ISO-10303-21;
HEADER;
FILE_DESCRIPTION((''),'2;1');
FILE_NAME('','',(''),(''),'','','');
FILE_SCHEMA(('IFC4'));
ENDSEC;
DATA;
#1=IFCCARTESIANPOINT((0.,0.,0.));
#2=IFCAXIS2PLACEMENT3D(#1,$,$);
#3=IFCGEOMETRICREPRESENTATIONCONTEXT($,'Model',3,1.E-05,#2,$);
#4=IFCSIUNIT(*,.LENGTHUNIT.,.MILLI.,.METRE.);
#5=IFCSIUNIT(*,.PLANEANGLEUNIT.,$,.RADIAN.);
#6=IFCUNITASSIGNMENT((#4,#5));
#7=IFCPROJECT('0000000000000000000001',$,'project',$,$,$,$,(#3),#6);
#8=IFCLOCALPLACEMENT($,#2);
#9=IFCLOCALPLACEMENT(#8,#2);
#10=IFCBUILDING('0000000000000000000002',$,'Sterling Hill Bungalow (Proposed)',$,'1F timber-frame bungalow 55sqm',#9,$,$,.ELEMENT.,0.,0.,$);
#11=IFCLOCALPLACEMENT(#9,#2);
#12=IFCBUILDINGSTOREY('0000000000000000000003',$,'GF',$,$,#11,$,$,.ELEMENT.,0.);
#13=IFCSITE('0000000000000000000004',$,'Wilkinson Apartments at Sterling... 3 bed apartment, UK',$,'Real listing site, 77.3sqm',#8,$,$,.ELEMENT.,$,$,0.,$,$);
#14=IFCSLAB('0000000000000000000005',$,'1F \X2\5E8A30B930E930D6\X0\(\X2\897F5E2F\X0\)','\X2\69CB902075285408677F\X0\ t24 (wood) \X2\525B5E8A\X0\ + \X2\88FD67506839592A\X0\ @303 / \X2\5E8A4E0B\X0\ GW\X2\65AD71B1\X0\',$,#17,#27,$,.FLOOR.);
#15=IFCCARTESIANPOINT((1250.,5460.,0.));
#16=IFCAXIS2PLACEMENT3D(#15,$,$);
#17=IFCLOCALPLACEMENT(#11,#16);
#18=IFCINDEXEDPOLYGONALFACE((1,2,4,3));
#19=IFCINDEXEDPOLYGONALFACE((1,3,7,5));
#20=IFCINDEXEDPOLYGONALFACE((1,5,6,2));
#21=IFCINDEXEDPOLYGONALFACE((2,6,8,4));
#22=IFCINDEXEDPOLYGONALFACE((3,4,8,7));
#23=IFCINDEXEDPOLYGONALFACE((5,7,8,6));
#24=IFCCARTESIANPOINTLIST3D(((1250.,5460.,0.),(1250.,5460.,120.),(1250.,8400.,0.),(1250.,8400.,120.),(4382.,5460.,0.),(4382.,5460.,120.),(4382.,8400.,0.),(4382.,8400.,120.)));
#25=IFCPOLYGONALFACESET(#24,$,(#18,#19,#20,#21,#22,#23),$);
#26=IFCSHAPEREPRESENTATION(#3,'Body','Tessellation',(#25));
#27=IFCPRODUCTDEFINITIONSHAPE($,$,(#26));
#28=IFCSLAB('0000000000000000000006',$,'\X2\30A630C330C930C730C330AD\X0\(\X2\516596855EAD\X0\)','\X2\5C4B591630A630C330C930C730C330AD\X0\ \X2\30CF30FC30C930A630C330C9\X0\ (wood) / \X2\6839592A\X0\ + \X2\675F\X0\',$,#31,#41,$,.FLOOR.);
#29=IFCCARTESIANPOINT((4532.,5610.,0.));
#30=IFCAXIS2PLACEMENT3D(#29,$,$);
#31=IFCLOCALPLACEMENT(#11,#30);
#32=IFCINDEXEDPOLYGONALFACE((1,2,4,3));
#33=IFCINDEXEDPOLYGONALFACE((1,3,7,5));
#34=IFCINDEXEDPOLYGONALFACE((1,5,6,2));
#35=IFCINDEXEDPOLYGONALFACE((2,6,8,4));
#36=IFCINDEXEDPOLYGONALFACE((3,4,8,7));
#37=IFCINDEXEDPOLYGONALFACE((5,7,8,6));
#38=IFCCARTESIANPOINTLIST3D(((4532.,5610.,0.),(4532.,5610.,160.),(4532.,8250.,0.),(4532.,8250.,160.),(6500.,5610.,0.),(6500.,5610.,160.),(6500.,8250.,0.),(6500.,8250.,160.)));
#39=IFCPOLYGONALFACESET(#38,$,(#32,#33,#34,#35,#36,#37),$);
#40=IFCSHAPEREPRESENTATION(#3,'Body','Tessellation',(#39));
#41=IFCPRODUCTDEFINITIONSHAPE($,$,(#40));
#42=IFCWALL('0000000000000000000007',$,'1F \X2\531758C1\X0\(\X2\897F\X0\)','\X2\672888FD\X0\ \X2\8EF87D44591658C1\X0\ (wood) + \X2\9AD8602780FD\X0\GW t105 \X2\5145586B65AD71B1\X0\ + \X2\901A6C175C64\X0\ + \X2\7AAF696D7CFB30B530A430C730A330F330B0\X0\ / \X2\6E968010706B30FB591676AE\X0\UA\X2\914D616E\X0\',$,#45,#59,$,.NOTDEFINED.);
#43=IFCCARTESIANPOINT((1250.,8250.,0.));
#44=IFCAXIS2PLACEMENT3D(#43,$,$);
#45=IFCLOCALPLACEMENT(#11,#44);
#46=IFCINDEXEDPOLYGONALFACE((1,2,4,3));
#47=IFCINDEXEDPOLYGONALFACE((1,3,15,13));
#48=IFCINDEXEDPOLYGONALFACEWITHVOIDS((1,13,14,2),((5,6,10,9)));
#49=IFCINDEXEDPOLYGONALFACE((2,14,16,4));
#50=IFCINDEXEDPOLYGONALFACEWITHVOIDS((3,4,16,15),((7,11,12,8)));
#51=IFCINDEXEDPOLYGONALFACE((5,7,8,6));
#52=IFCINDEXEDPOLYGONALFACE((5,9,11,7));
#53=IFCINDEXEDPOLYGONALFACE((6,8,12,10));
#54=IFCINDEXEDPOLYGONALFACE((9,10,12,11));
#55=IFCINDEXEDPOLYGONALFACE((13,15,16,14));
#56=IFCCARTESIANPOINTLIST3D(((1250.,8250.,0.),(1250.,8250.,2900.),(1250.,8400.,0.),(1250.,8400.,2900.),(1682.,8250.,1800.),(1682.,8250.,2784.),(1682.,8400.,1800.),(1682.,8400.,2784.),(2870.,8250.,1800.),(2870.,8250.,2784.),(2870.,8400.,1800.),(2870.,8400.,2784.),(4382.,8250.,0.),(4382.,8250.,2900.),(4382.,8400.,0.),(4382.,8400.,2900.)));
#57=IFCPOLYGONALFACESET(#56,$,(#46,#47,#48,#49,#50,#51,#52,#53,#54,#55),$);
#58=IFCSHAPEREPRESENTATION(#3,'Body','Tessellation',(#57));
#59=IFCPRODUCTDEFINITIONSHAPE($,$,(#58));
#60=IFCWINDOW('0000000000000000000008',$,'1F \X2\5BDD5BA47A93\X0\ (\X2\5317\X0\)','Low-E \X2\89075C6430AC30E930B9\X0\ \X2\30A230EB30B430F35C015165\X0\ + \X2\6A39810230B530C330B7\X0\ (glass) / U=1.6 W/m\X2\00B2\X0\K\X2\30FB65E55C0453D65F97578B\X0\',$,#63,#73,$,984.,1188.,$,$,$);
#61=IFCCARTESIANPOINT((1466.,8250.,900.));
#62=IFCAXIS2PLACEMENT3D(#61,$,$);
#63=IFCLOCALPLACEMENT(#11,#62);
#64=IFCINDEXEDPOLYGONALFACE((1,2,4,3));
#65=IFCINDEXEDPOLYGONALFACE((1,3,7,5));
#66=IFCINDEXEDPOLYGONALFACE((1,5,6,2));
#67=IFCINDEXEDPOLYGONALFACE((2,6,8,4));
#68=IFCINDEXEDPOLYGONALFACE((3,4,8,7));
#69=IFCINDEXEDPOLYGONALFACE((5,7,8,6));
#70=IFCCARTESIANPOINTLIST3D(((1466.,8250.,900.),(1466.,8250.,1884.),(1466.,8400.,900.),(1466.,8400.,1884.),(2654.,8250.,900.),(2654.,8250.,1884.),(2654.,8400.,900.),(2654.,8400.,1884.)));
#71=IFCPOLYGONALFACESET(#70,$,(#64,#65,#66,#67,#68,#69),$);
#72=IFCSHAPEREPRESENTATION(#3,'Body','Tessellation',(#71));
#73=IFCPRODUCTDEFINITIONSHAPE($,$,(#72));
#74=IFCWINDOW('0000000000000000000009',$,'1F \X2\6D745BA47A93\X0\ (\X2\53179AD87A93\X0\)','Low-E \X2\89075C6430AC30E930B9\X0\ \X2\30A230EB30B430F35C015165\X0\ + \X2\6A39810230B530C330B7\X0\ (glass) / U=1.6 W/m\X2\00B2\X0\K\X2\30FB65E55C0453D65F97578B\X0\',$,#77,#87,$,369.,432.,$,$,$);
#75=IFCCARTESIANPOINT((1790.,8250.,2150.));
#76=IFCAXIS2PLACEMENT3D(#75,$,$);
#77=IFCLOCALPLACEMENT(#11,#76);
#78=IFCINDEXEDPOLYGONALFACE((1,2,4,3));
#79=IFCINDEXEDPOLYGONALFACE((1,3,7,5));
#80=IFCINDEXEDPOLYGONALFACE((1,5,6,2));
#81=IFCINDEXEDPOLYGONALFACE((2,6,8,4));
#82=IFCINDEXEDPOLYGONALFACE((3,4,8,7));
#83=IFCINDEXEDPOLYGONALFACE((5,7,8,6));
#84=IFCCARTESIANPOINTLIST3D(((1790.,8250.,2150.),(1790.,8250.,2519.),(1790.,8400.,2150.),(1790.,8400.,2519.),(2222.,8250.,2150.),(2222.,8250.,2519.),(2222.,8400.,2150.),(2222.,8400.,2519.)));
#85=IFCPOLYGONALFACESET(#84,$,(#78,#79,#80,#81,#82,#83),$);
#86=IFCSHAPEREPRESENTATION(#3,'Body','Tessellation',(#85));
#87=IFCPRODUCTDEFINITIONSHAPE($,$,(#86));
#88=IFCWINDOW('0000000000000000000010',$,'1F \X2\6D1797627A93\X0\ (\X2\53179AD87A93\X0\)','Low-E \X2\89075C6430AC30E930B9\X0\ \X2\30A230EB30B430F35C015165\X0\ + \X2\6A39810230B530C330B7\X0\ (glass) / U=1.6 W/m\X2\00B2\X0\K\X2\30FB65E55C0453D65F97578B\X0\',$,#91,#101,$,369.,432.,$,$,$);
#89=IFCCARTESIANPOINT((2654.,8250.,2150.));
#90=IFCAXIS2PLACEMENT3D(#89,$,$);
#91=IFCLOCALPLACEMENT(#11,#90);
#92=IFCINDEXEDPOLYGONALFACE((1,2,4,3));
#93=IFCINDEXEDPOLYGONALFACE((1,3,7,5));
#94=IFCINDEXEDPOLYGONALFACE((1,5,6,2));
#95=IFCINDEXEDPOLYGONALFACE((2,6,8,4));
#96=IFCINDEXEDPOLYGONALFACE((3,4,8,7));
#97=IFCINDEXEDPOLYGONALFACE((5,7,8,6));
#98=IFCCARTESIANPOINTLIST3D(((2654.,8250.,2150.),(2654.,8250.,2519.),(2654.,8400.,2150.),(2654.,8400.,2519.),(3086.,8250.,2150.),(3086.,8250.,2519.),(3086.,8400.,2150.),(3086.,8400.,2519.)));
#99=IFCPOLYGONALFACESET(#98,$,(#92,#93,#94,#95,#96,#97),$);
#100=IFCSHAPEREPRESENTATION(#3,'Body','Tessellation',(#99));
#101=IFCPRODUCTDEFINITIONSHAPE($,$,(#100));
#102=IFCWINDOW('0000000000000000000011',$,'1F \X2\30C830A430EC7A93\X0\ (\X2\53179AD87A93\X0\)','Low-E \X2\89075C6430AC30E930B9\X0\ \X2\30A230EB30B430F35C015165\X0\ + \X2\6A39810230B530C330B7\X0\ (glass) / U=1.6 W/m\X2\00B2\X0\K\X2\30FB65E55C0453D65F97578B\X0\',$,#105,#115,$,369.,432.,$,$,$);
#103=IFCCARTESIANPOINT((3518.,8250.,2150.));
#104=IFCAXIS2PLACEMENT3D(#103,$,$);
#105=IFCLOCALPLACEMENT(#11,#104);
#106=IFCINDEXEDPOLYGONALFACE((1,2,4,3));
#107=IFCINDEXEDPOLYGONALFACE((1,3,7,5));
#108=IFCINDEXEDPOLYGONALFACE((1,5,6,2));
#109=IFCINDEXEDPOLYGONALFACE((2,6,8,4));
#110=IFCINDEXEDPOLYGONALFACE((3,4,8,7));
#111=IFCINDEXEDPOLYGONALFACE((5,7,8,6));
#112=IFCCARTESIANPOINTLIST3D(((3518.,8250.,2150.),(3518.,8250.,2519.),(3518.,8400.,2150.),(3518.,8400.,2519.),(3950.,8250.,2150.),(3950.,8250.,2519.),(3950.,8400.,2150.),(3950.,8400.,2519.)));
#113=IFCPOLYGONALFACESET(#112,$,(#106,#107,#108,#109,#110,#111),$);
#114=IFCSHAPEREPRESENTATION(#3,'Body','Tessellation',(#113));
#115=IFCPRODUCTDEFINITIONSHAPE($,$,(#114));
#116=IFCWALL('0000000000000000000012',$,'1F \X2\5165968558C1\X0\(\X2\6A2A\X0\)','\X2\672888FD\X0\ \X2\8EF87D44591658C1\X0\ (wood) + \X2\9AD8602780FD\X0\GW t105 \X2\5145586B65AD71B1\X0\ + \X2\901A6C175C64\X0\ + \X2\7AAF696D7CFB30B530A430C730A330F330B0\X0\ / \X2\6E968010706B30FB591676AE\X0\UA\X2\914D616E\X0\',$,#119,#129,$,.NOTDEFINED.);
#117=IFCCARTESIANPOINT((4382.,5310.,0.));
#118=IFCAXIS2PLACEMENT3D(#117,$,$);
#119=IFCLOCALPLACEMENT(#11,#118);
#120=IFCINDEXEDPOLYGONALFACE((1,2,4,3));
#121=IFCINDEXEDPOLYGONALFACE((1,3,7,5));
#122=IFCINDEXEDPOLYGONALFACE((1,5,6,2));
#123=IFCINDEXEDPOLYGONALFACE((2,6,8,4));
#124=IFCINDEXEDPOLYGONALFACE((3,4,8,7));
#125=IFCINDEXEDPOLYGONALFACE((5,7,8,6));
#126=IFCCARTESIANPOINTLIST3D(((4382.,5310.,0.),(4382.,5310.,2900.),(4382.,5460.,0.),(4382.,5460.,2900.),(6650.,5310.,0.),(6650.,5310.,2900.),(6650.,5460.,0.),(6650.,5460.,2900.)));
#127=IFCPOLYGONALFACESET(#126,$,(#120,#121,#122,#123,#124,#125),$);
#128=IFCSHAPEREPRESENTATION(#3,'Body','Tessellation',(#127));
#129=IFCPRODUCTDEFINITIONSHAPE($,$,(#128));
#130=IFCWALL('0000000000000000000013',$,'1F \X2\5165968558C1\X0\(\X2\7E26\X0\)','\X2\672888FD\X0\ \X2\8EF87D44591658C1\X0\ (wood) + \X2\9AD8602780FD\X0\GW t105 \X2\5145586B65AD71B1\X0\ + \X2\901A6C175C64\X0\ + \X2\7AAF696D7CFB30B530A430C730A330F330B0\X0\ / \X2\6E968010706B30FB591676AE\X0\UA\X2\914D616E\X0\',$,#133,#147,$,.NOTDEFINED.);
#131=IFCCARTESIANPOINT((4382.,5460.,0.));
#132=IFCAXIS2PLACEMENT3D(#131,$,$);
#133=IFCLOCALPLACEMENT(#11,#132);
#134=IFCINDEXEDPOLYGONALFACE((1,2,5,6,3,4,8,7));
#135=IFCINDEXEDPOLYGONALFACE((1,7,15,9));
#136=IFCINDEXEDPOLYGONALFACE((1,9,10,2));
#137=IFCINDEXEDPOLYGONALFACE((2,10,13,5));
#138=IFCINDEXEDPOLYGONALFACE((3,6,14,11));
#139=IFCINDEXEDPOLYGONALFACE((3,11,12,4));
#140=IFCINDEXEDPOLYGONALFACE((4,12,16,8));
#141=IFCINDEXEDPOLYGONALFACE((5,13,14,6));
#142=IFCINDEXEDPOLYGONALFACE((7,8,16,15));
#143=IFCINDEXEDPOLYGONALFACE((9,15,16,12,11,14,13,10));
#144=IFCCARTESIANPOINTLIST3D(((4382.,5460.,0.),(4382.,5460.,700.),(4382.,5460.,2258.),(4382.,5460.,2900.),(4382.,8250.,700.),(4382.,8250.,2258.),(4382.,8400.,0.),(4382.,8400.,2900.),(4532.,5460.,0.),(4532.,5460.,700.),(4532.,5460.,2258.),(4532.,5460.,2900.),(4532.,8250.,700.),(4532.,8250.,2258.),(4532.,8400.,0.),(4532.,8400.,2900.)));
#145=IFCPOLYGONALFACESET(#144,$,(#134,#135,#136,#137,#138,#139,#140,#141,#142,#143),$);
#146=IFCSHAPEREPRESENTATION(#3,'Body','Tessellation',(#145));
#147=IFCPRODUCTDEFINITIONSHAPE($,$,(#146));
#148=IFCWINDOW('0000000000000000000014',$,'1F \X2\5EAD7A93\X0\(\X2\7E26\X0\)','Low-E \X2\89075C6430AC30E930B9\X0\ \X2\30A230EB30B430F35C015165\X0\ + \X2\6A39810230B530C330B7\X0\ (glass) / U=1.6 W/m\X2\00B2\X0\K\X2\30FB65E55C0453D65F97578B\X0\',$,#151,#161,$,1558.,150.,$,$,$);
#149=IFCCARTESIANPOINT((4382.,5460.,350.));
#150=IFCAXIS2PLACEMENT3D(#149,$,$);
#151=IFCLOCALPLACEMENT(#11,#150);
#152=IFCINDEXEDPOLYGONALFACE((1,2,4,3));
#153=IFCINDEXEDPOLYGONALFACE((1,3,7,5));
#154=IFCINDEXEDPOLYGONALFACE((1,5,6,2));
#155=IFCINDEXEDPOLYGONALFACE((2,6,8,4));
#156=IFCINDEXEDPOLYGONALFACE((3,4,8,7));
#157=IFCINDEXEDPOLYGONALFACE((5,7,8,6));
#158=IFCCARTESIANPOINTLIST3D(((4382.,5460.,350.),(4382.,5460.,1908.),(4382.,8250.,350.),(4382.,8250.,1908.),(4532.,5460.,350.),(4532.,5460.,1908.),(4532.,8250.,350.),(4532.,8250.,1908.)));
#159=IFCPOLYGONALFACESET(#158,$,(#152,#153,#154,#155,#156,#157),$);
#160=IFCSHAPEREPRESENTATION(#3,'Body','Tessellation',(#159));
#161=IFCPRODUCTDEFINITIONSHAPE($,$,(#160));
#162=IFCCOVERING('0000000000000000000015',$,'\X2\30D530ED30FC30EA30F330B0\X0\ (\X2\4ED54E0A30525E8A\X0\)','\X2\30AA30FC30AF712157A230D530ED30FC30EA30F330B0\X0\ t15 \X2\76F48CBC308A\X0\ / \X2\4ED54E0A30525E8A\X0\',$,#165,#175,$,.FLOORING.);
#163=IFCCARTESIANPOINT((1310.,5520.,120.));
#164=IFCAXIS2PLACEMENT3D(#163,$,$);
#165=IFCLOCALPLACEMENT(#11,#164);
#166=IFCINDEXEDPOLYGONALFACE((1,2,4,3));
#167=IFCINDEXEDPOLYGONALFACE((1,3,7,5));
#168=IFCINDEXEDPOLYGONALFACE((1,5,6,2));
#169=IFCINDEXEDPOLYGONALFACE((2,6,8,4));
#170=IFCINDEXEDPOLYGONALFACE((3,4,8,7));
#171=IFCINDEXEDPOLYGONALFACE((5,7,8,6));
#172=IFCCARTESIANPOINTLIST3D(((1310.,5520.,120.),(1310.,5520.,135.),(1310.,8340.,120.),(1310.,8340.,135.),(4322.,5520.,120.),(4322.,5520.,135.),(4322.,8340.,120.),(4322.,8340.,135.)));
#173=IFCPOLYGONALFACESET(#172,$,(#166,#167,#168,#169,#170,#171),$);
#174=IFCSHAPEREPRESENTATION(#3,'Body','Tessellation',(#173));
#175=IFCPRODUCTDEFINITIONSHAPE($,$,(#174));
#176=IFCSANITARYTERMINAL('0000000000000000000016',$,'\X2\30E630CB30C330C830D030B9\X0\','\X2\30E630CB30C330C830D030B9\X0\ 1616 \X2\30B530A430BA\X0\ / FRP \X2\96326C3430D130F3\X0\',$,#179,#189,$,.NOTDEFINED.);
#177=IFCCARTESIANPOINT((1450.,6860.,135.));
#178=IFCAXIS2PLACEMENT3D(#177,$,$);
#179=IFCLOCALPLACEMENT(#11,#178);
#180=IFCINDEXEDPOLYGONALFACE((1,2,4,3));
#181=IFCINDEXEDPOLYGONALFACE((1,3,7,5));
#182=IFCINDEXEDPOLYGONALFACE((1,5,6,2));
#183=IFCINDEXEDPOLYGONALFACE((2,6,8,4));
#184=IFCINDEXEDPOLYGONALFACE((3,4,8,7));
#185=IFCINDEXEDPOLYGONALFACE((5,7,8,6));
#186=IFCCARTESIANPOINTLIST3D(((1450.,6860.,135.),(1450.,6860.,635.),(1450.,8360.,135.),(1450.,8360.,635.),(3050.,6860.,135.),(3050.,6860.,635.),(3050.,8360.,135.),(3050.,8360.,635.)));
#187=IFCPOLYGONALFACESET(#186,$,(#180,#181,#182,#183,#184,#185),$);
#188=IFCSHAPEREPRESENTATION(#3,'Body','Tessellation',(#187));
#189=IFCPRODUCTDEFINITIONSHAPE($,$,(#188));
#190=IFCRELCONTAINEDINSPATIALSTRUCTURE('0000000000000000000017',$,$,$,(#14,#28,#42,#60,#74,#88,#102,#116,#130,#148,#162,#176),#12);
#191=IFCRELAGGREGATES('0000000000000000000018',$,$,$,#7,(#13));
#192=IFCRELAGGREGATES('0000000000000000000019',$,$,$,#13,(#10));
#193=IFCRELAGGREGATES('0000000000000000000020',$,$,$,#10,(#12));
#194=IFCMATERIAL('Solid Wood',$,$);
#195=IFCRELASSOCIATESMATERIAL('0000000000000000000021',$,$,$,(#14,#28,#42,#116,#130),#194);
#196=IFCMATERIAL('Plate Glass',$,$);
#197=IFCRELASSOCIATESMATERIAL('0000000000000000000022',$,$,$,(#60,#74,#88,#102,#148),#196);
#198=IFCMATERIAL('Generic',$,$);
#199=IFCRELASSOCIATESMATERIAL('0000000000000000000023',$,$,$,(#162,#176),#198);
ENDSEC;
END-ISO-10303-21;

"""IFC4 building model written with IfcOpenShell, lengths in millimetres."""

from ifc_helpers import new_model, si_unit, frame, frame_2d, origin, place, context, project, spatial, rectangle, extrude, material, element, fill, save


model = new_model("IFC4")

# Units and contexts
model_context = context("Model", 3, precision=1e-05, world=origin())
ifc_project = project(units=[si_unit("LENGTHUNIT", "METRE", prefix="MILLI"), si_unit("PLANEANGLEUNIT", "RADIAN")], contexts=[model_context])

# Site, building, storey
site_placement = place(None, origin())
site = spatial("IfcSite", under=ifc_project, at=site_placement, Name="Wilkinson Apartments at Sterling... 3 bed apartment, UK", ObjectType="Real listing site, 77.3sqm", CompositionType="ELEMENT", RefElevation=0.0)
building_placement = place(site_placement, origin())
building = spatial("IfcBuilding", under=site, at=building_placement, Name="Sterling Hill Bungalow (Proposed)", ObjectType="1F timber-frame bungalow 55sqm", CompositionType="ELEMENT", ElevationOfRefHeight=0.0, ElevationOfTerrain=0.0)
storey_placement = place(building_placement, origin())
storey = spatial("IfcBuildingStorey", under=building, at=storey_placement, Name="GF", CompositionType="ELEMENT", Elevation=0.0)

# Slabs
ifc_material_1 = material(Name="Solid Wood")
slab_1_placement = place(storey_placement, frame((1250.0, 5460.0, 0.0)))
element("IfcSlab", 1, at=slab_1_placement, inside=storey, material=ifc_material_1, Name="1F 床スラブ(西帯)", Description="構造用合板 t24 (wood) 剛床 + 製材根太 @303 / 床下 GW断熱", PredefinedType="FLOOR", context=model_context, shape_type="SweptSolid", body=[
    extrude(rectangle(XDim=3132.0, YDim=2940.0, at=frame_2d((1566.0, 1470.0))), frame((1250.0, 5460.0, 0.0)), (0.0, 0.0, 1.0), 120.0),
])
slab_2_placement = place(storey_placement, frame((4532.0, 5610.0, 0.0)))
element("IfcSlab", 2, at=slab_2_placement, inside=storey, material=ifc_material_1, Name="ウッドデッキ(入隅庭)", Description="屋外ウッドデッキ ハードウッド (wood) / 根太 + 束", PredefinedType="FLOOR", context=model_context, shape_type="SweptSolid", body=[
    extrude(rectangle(XDim=1968.0, YDim=2640.0, at=frame_2d((984.0, 1320.0))), frame((4532.0, 5610.0, 0.0)), (0.0, 0.0, 1.0), 160.0),
])

# Wall, openings, windows
wall_1_placement = place(storey_placement, frame((1250.0, 8250.0, 0.0)))
wall_1 = element("IfcWall", 3, at=wall_1_placement, inside=storey, material=ifc_material_1, Name="1F 北壁(西)", Description="木製 軸組外壁 (wood) + 高性能GW t105 充填断熱 + 通気層 + 窯業系サイディング / 準耐火・外皮UA配慮", PredefinedType="NOTDEFINED", context=model_context, shape_type="SweptSolid", body=[
    extrude(rectangle(XDim=3132.0, YDim=150.0, at=frame_2d((1566.0, 75.0))), frame((1250.0, 8250.0, 0.0)), (0.0, 0.0, 1.0), 2900.0),
])
opening_1_placement = place(storey_placement, frame((1466.0, 8250.0, 900.0)))
opening_1 = element("IfcOpeningElement", 4, at=opening_1_placement, cuts=wall_1, PredefinedType="NOTDEFINED", context=model_context, shape_type="SweptSolid", body=[
    extrude(rectangle(XDim=1188.0, YDim=150.0, at=frame_2d((594.0, 75.0))), frame((1466.0, 8250.0, 900.0)), (0.0, 0.0, 1.0), 984.0),
])
opening_2_placement = place(storey_placement, frame((1790.0, 8250.0, 2150.0)))
opening_2 = element("IfcOpeningElement", 5, at=opening_2_placement, cuts=wall_1, PredefinedType="NOTDEFINED", context=model_context, shape_type="SweptSolid", body=[
    extrude(rectangle(XDim=432.0, YDim=150.0, at=frame_2d((216.0, 75.0))), frame((1790.0, 8250.0, 2150.0)), (0.0, 0.0, 1.0), 369.0),
])
opening_3_placement = place(storey_placement, frame((2654.0, 8250.0, 2150.0)))
opening_3 = element("IfcOpeningElement", 6, at=opening_3_placement, cuts=wall_1, PredefinedType="NOTDEFINED", context=model_context, shape_type="SweptSolid", body=[
    extrude(rectangle(XDim=432.0, YDim=150.0, at=frame_2d((216.0, 75.0))), frame((2654.0, 8250.0, 2150.0)), (0.0, 0.0, 1.0), 369.0),
])
opening_4_placement = place(storey_placement, frame((3518.0, 8250.0, 2150.0)))
opening_4 = element("IfcOpeningElement", 7, at=opening_4_placement, cuts=wall_1, PredefinedType="NOTDEFINED", context=model_context, shape_type="SweptSolid", body=[
    extrude(rectangle(XDim=432.0, YDim=150.0, at=frame_2d((216.0, 75.0))), frame((3518.0, 8250.0, 2150.0)), (0.0, 0.0, 1.0), 369.0),
])
ifc_material_2 = material(Name="Plate Glass")
window_1_placement = place(storey_placement, frame((1466.0, 8250.0, 900.0)))
window_1 = element("IfcWindow", 8, at=window_1_placement, inside=storey, material=ifc_material_2, Name="1F 寝室窓 (北)", Description="Low-E 複層ガラス アルゴン封入 + 樹脂サッシ (glass) / U=1.6 W/m²K・日射取得型", OverallHeight=984.0, OverallWidth=1188.0, context=model_context, shape_type="SweptSolid", body=[
    extrude(rectangle(XDim=1188.0, YDim=150.0, at=frame_2d((594.0, 75.0))), frame((1466.0, 8250.0, 900.0)), (0.0, 0.0, 1.0), 984.0),
])
fill(opening_1, window_1)
window_2_placement = place(storey_placement, frame((1790.0, 8250.0, 2150.0)))
window_2 = element("IfcWindow", 9, at=window_2_placement, inside=storey, material=ifc_material_2, Name="1F 浴室窓 (北高窓)", Description="Low-E 複層ガラス アルゴン封入 + 樹脂サッシ (glass) / U=1.6 W/m²K・日射取得型", OverallHeight=369.0, OverallWidth=432.0, context=model_context, shape_type="SweptSolid", body=[
    extrude(rectangle(XDim=432.0, YDim=150.0, at=frame_2d((216.0, 75.0))), frame((1790.0, 8250.0, 2150.0)), (0.0, 0.0, 1.0), 369.0),
])
fill(opening_2, window_2)
window_3_placement = place(storey_placement, frame((2654.0, 8250.0, 2150.0)))
window_3 = element("IfcWindow", 10, at=window_3_placement, inside=storey, material=ifc_material_2, Name="1F 洗面窓 (北高窓)", Description="Low-E 複層ガラス アルゴン封入 + 樹脂サッシ (glass) / U=1.6 W/m²K・日射取得型", OverallHeight=369.0, OverallWidth=432.0, context=model_context, shape_type="SweptSolid", body=[
    extrude(rectangle(XDim=432.0, YDim=150.0, at=frame_2d((216.0, 75.0))), frame((2654.0, 8250.0, 2150.0)), (0.0, 0.0, 1.0), 369.0),
])
fill(opening_3, window_3)
window_4_placement = place(storey_placement, frame((3518.0, 8250.0, 2150.0)))
window_4 = element("IfcWindow", 11, at=window_4_placement, inside=storey, material=ifc_material_2, Name="1F トイレ窓 (北高窓)", Description="Low-E 複層ガラス アルゴン封入 + 樹脂サッシ (glass) / U=1.6 W/m²K・日射取得型", OverallHeight=369.0, OverallWidth=432.0, context=model_context, shape_type="SweptSolid", body=[
    extrude(rectangle(XDim=432.0, YDim=150.0, at=frame_2d((216.0, 75.0))), frame((3518.0, 8250.0, 2150.0)), (0.0, 0.0, 1.0), 369.0),
])
fill(opening_4, window_4)

# Wall
wall_2_placement = place(storey_placement, frame((4382.0, 5310.0, 0.0)))
element("IfcWall", 12, at=wall_2_placement, inside=storey, material=ifc_material_1, Name="1F 入隅壁(横)", Description="木製 軸組外壁 (wood) + 高性能GW t105 充填断熱 + 通気層 + 窯業系サイディング / 準耐火・外皮UA配慮", PredefinedType="NOTDEFINED", context=model_context, shape_type="SweptSolid", body=[
    extrude(rectangle(XDim=2268.0, YDim=150.0, at=frame_2d((1134.0, 75.0))), frame((4382.0, 5310.0, 0.0)), (0.0, 0.0, 1.0), 2900.0),
])

# Wall, opening, window
wall_3_placement = place(storey_placement, frame((4382.0, 5460.0, 0.0)))
wall_3 = element("IfcWall", 13, at=wall_3_placement, inside=storey, material=ifc_material_1, Name="1F 入隅壁(縦)", Description="木製 軸組外壁 (wood) + 高性能GW t105 充填断熱 + 通気層 + 窯業系サイディング / 準耐火・外皮UA配慮", PredefinedType="NOTDEFINED", context=model_context, shape_type="SweptSolid", body=[
    extrude(rectangle(XDim=150.0, YDim=2940.0, at=frame_2d((75.0, 1470.0))), frame((4382.0, 5460.0, 0.0)), (0.0, 0.0, 1.0), 2900.0),
])
opening_5_placement = place(storey_placement, frame((4382.0, 5460.0, 350.0)))
opening_5 = element("IfcOpeningElement", 14, at=opening_5_placement, cuts=wall_3, PredefinedType="NOTDEFINED", context=model_context, shape_type="SweptSolid", body=[
    extrude(rectangle(XDim=150.0, YDim=2790.0, at=frame_2d((75.0, 1395.0))), frame((4382.0, 5460.0, 350.0)), (0.0, 0.0, 1.0), 1558.0),
])
window_5_placement = place(storey_placement, frame((4382.0, 5460.0, 350.0)))
window_5 = element("IfcWindow", 15, at=window_5_placement, inside=storey, material=ifc_material_2, Name="1F 庭窓(縦)", Description="Low-E 複層ガラス アルゴン封入 + 樹脂サッシ (glass) / U=1.6 W/m²K・日射取得型", OverallHeight=1558.0, OverallWidth=150.0, context=model_context, shape_type="SweptSolid", body=[
    extrude(rectangle(XDim=150.0, YDim=2790.0, at=frame_2d((75.0, 1395.0))), frame((4382.0, 5460.0, 350.0)), (0.0, 0.0, 1.0), 1558.0),
])
fill(opening_5, window_5)

# Covering
ifc_material_3 = material(Name="Generic")
covering_placement = place(storey_placement, frame((1310.0, 5520.0, 120.0)))
element("IfcCovering", 16, at=covering_placement, inside=storey, material=ifc_material_3, Name="フローリング (仕上げ床)", Description="オーク無垢フローリング t15 直貼り / 仕上げ床", PredefinedType="FLOORING", context=model_context, shape_type="SweptSolid", body=[
    extrude(rectangle(XDim=3012.0, YDim=2820.0, at=frame_2d((1506.0, 1410.0))), frame((1310.0, 5520.0, 120.0)), (0.0, 0.0, 1.0), 15.0),
])

# Sanitary terminal
sanitary_terminal_1_placement = place(storey_placement, frame((1450.0, 6860.0, 135.0)))
element("IfcSanitaryTerminal", 17, at=sanitary_terminal_1_placement, inside=storey, material=ifc_material_3, Name="ユニットバス", Description="ユニットバス 1616 サイズ / FRP 防水パン", PredefinedType="NOTDEFINED", context=model_context, shape_type="SweptSolid", body=[
    extrude(rectangle(XDim=1600.0, YDim=1500.0, at=frame_2d((800.0, 750.0))), frame((1450.0, 6860.0, 135.0)), (0.0, 0.0, 1.0), 500.0),
])

save(model, "model.ifc")
